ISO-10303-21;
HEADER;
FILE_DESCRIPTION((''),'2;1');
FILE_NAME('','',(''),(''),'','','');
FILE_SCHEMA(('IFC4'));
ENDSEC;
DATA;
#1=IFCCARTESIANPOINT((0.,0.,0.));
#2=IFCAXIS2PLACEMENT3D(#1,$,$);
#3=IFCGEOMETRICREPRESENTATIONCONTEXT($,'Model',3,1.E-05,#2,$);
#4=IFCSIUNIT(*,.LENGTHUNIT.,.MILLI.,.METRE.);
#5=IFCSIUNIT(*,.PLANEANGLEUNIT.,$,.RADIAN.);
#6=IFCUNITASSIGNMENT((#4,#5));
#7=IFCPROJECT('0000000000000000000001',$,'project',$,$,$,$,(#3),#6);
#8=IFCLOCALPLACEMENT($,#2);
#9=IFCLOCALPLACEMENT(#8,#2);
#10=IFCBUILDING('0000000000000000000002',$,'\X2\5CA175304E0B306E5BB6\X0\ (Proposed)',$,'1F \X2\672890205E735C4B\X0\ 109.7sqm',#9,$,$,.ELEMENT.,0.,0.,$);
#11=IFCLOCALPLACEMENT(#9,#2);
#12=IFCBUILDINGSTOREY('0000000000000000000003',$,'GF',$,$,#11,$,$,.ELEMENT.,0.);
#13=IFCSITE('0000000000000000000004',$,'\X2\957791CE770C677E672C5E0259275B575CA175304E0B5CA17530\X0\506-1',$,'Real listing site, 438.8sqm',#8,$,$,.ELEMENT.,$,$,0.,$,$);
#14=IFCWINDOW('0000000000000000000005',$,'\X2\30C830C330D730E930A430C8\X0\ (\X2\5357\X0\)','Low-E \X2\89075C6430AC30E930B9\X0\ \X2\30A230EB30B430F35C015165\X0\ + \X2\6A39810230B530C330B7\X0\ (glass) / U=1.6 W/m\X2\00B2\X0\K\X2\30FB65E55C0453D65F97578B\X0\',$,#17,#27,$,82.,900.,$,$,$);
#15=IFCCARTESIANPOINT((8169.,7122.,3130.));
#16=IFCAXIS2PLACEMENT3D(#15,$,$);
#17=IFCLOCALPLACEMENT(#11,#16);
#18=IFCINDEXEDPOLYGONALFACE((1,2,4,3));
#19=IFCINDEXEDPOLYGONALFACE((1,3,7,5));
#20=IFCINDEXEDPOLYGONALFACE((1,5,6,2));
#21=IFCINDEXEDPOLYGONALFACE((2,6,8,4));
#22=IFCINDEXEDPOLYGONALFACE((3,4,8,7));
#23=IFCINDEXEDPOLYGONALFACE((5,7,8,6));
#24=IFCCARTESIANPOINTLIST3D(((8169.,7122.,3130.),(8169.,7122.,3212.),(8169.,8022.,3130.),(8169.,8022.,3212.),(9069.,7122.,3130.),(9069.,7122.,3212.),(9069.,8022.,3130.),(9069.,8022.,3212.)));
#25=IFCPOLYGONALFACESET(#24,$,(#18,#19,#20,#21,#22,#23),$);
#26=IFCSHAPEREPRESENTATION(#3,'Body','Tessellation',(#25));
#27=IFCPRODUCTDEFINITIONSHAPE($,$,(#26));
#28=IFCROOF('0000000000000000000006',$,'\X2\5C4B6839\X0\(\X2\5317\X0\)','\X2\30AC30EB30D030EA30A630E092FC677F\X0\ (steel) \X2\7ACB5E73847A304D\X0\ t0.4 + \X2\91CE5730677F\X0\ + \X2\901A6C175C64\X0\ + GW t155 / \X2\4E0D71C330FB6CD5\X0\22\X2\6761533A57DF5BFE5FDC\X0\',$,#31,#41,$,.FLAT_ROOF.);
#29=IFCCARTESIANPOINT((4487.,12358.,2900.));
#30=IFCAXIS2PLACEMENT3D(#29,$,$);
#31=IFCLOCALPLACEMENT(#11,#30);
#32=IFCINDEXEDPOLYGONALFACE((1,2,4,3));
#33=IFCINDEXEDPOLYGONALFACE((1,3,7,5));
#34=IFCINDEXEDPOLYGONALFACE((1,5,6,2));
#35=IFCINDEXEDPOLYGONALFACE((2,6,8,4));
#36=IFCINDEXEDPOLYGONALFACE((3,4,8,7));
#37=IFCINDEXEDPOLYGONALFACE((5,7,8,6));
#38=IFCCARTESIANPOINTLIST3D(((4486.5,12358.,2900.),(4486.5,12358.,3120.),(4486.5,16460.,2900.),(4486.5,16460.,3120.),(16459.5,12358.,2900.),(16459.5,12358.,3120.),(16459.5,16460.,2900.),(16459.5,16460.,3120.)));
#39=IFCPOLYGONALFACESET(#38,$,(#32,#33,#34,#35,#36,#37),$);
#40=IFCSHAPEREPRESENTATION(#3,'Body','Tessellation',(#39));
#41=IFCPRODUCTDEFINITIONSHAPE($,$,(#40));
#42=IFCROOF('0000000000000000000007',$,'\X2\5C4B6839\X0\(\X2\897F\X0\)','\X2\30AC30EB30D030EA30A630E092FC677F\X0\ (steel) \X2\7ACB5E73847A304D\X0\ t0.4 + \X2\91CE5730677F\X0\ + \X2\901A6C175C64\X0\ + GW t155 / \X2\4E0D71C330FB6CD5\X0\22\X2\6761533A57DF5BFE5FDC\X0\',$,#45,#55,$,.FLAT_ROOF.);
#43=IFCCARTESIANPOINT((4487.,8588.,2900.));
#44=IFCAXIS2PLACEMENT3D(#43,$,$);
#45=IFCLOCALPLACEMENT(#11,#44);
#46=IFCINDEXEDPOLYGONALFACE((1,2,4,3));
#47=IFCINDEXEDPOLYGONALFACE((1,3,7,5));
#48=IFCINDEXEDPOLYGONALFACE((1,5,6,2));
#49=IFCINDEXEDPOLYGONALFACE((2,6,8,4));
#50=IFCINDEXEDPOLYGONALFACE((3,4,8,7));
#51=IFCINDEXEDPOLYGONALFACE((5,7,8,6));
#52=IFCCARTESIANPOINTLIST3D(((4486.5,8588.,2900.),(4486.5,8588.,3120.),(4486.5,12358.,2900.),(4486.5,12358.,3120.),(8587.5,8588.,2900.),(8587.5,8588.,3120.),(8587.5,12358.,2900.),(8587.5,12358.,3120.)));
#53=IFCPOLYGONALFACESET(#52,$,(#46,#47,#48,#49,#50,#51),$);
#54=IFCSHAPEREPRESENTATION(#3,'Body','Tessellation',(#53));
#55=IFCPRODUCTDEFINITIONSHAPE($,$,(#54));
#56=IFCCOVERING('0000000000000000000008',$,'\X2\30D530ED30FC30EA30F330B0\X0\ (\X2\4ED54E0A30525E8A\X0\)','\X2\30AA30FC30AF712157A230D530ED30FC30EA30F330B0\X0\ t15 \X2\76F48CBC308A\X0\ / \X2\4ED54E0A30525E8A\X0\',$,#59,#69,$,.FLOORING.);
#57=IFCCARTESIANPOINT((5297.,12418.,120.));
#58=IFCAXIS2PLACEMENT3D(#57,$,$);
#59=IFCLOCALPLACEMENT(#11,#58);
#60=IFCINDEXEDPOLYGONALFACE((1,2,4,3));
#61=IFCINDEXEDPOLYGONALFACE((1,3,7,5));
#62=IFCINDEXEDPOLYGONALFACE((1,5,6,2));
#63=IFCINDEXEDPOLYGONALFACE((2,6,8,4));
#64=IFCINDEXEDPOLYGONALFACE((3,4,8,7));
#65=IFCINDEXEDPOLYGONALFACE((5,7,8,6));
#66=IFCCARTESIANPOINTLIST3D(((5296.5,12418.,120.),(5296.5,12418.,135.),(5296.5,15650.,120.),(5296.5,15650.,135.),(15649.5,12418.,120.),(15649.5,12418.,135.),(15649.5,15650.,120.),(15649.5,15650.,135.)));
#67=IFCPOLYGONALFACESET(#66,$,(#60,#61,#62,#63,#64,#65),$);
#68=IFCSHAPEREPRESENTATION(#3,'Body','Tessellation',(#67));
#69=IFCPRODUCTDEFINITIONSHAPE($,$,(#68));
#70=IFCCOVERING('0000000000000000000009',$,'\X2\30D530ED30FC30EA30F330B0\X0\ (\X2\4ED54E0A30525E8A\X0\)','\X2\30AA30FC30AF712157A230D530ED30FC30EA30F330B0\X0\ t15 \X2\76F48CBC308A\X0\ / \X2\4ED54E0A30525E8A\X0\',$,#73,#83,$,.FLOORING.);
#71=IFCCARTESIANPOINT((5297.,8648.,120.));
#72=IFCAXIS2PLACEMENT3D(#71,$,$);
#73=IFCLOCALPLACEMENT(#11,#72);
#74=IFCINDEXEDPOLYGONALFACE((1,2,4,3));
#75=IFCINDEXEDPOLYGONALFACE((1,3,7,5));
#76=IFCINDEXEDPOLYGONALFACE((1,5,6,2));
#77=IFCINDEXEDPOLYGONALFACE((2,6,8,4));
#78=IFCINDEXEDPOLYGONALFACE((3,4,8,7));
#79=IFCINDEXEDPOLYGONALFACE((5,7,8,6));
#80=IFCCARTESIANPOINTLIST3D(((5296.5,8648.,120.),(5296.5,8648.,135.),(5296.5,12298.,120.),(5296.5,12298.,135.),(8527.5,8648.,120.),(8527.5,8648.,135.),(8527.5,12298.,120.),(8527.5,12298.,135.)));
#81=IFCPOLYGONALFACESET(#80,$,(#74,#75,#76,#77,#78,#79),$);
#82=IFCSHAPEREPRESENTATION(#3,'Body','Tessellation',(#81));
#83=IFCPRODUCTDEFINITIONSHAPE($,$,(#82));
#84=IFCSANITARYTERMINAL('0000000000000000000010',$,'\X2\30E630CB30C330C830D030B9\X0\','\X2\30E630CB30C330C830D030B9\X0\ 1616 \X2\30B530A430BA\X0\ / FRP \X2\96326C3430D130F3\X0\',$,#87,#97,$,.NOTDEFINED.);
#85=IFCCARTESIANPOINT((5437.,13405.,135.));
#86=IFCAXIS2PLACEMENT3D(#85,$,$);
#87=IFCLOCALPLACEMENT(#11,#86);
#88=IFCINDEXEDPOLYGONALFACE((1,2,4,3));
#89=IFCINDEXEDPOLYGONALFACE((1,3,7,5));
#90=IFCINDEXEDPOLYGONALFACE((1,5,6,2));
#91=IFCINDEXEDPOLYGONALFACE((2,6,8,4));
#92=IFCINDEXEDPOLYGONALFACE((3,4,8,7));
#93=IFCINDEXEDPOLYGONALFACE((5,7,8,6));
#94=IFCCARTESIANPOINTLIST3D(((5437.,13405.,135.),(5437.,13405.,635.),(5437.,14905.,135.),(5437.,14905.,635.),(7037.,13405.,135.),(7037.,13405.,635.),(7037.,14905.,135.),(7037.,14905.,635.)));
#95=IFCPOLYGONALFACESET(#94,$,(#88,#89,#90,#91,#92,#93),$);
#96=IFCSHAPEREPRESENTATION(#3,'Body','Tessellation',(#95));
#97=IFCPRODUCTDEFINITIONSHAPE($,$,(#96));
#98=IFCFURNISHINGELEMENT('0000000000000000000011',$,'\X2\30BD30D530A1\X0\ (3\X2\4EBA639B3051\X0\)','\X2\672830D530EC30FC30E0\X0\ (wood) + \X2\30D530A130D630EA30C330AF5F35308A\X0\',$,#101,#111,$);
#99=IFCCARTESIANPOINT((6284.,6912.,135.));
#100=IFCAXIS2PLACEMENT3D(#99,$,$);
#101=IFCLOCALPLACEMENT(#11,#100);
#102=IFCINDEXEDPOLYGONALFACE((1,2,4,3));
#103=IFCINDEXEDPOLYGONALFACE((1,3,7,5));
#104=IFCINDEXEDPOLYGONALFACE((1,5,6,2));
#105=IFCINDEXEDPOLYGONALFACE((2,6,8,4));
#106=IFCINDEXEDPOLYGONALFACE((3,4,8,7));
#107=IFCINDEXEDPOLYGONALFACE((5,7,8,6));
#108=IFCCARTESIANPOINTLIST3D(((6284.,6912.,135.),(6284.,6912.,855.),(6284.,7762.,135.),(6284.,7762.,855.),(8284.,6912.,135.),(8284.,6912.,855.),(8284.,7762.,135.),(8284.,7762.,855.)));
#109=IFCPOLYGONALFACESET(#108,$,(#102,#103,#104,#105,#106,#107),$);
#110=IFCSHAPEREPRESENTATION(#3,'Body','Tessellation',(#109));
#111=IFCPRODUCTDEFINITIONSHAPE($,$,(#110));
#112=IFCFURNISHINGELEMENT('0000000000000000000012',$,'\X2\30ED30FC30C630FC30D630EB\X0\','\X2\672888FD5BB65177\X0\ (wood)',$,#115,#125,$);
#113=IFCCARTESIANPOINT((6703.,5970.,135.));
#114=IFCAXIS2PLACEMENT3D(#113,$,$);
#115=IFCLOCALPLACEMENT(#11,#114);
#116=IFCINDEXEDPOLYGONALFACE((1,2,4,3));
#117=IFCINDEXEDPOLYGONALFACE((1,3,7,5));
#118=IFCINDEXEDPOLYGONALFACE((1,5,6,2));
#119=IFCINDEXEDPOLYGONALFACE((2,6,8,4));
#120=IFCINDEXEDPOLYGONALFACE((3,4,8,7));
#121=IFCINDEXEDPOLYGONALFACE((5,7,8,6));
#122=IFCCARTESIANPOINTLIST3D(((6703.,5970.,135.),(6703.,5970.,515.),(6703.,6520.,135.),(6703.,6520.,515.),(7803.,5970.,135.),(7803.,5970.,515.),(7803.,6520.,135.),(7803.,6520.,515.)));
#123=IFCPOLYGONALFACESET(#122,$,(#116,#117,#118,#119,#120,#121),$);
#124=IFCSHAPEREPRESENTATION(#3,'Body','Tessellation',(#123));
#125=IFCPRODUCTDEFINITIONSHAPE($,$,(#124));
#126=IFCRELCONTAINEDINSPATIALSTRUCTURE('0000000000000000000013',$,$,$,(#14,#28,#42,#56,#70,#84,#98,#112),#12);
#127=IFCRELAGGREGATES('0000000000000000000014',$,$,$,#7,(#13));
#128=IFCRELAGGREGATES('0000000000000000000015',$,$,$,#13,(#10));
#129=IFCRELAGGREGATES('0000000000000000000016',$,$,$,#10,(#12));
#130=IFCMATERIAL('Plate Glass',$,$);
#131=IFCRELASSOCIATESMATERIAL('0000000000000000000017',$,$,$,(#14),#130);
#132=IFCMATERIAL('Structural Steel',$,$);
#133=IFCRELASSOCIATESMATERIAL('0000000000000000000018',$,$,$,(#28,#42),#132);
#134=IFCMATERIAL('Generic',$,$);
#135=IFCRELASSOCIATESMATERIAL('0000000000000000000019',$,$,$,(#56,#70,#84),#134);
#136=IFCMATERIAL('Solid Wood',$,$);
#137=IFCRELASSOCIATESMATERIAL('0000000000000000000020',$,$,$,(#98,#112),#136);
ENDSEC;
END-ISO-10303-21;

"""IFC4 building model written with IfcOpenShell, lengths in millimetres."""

from ifc_helpers import new_model, si_unit, frame, frame_2d, origin, place, context, project, spatial, rectangle, extrude, material, element, save


model = new_model("IFC4")

# Units and contexts
model_context = context("Model", 3, precision=1e-05, world=origin())
ifc_project = project(units=[si_unit("LENGTHUNIT", "METRE", prefix="MILLI"), si_unit("PLANEANGLEUNIT", "RADIAN")], contexts=[model_context])

# Site, building, storey
site_placement = place(None, origin())
site = spatial("IfcSite", under=ifc_project, at=site_placement, Name="長野県松本市大字岡田下岡田506-1", ObjectType="Real listing site, 438.8sqm", CompositionType="ELEMENT", RefElevation=0.0)
building_placement = place(site_placement, origin())
building = spatial("IfcBuilding", under=site, at=building_placement, Name="岡田下の家 (Proposed)", ObjectType="1F 木造平屋 109.7sqm", CompositionType="ELEMENT", ElevationOfRefHeight=0.0, ElevationOfTerrain=0.0)
storey_placement = place(building_placement, origin())
storey = spatial("IfcBuildingStorey", under=building, at=storey_placement, Name="GF", CompositionType="ELEMENT", Elevation=0.0)

# Shared definitions
ifc_material_1 = material(Name="Solid Wood")

# Shared definitions
ifc_material_2 = material(Name="Plate Glass")

# Window
window_1_placement = place(storey_placement, frame((8169.0, 7122.0, 3130.0)))
element("IfcWindow", 1, at=window_1_placement, inside=storey, material=ifc_material_2, Name="トップライト (南)", Description="Low-E 複層ガラス アルゴン封入 + 樹脂サッシ (glass) / U=1.6 W/m²K・日射取得型", OverallHeight=82.0, OverallWidth=900.0, context=model_context, shape_type="SweptSolid", body=[
    extrude(rectangle(XDim=900.0, YDim=900.0, at=frame_2d((450.0, 450.0))), frame((8169.0, 7122.0, 3130.0)), (0.0, 0.0, 1.0), 82.0),
])

# Roofs
ifc_material_3 = material(Name="Structural Steel")
roof_1_placement = place(storey_placement, frame((4487.0, 12358.0, 2900.0)))
element("IfcRoof", 2, at=roof_1_placement, inside=storey, material=ifc_material_3, Name="屋根(北)", Description="ガルバリウム鋼板 (steel) 立平葺き t0.4 + 野地板 + 通気層 + GW t155 / 不燃・法22条区域対応", PredefinedType="FLAT_ROOF", context=model_context, shape_type="SweptSolid", body=[
    extrude(rectangle(XDim=11973.0, YDim=4102.0, at=frame_2d((5986.0, 2051.0))), frame((4487.0, 12358.0, 2900.0)), (0.0, 0.0, 1.0), 220.0),
])
roof_2_placement = place(storey_placement, frame((4487.0, 8588.0, 2900.0)))
element("IfcRoof", 3, at=roof_2_placement, inside=storey, material=ifc_material_3, Name="屋根(西)", Description="ガルバリウム鋼板 (steel) 立平葺き t0.4 + 野地板 + 通気層 + GW t155 / 不燃・法22条区域対応", PredefinedType="FLAT_ROOF", context=model_context, shape_type="SweptSolid", body=[
    extrude(rectangle(XDim=4101.0, YDim=3770.0, at=frame_2d((2050.0, 1885.0))), frame((4487.0, 8588.0, 2900.0)), (0.0, 0.0, 1.0), 220.0),
])

# Coverings
ifc_material_4 = material(Name="Generic")
covering_1_placement = place(storey_placement, frame((5297.0, 12418.0, 120.0)))
element("IfcCovering", 4, at=covering_1_placement, inside=storey, material=ifc_material_4, Name="フローリング (仕上げ床)", Description="オーク無垢フローリング t15 直貼り / 仕上げ床", PredefinedType="FLOORING", context=model_context, shape_type="SweptSolid", body=[
    extrude(rectangle(XDim=10353.0, YDim=3232.0, at=frame_2d((5176.0, 1616.0))), frame((5297.0, 12418.0, 120.0)), (0.0, 0.0, 1.0), 15.0),
])
covering_2_placement = place(storey_placement, frame((5297.0, 8648.0, 120.0)))
element("IfcCovering", 5, at=covering_2_placement, inside=storey, material=ifc_material_4, Name="フローリング (仕上げ床)", Description="オーク無垢フローリング t15 直貼り / 仕上げ床", PredefinedType="FLOORING", context=model_context, shape_type="SweptSolid", body=[
    extrude(rectangle(XDim=3231.0, YDim=3650.0, at=frame_2d((1615.0, 1825.0))), frame((5297.0, 8648.0, 120.0)), (0.0, 0.0, 1.0), 15.0),
])

# Sanitary terminal
sanitary_terminal_placement = place(storey_placement, frame((5437.0, 13405.0, 135.0)))
element("IfcSanitaryTerminal", 6, at=sanitary_terminal_placement, inside=storey, material=ifc_material_4, Name="ユニットバス", Description="ユニットバス 1616 サイズ / FRP 防水パン", PredefinedType="NOTDEFINED", context=model_context, shape_type="SweptSolid", body=[
    extrude(rectangle(XDim=1600.0, YDim=1500.0, at=frame_2d((800.0, 750.0))), frame((5437.0, 13405.0, 135.0)), (0.0, 0.0, 1.0), 500.0),
])

# Furnishing elements
furnishing_1_placement = place(storey_placement, frame((6284.0, 6912.0, 135.0)))
element("IfcFurnishingElement", 7, at=furnishing_1_placement, inside=storey, material=ifc_material_1, Name="ソファ (3人掛け)", Description="木フレーム (wood) + ファブリック張り", context=model_context, shape_type="SweptSolid", body=[
    extrude(rectangle(XDim=2000.0, YDim=850.0, at=frame_2d((1000.0, 425.0))), frame((6284.0, 6912.0, 135.0)), (0.0, 0.0, 1.0), 720.0),
])
furnishing_2_placement = place(storey_placement, frame((6703.0, 5970.0, 135.0)))
element("IfcFurnishingElement", 8, at=furnishing_2_placement, inside=storey, material=ifc_material_1, Name="ローテーブル", Description="木製家具 (wood)", context=model_context, shape_type="SweptSolid", body=[
    extrude(rectangle(XDim=1100.0, YDim=550.0, at=frame_2d((550.0, 275.0))), frame((6703.0, 5970.0, 135.0)), (0.0, 0.0, 1.0), 380.0),
])

save(model, "model.ifc")
